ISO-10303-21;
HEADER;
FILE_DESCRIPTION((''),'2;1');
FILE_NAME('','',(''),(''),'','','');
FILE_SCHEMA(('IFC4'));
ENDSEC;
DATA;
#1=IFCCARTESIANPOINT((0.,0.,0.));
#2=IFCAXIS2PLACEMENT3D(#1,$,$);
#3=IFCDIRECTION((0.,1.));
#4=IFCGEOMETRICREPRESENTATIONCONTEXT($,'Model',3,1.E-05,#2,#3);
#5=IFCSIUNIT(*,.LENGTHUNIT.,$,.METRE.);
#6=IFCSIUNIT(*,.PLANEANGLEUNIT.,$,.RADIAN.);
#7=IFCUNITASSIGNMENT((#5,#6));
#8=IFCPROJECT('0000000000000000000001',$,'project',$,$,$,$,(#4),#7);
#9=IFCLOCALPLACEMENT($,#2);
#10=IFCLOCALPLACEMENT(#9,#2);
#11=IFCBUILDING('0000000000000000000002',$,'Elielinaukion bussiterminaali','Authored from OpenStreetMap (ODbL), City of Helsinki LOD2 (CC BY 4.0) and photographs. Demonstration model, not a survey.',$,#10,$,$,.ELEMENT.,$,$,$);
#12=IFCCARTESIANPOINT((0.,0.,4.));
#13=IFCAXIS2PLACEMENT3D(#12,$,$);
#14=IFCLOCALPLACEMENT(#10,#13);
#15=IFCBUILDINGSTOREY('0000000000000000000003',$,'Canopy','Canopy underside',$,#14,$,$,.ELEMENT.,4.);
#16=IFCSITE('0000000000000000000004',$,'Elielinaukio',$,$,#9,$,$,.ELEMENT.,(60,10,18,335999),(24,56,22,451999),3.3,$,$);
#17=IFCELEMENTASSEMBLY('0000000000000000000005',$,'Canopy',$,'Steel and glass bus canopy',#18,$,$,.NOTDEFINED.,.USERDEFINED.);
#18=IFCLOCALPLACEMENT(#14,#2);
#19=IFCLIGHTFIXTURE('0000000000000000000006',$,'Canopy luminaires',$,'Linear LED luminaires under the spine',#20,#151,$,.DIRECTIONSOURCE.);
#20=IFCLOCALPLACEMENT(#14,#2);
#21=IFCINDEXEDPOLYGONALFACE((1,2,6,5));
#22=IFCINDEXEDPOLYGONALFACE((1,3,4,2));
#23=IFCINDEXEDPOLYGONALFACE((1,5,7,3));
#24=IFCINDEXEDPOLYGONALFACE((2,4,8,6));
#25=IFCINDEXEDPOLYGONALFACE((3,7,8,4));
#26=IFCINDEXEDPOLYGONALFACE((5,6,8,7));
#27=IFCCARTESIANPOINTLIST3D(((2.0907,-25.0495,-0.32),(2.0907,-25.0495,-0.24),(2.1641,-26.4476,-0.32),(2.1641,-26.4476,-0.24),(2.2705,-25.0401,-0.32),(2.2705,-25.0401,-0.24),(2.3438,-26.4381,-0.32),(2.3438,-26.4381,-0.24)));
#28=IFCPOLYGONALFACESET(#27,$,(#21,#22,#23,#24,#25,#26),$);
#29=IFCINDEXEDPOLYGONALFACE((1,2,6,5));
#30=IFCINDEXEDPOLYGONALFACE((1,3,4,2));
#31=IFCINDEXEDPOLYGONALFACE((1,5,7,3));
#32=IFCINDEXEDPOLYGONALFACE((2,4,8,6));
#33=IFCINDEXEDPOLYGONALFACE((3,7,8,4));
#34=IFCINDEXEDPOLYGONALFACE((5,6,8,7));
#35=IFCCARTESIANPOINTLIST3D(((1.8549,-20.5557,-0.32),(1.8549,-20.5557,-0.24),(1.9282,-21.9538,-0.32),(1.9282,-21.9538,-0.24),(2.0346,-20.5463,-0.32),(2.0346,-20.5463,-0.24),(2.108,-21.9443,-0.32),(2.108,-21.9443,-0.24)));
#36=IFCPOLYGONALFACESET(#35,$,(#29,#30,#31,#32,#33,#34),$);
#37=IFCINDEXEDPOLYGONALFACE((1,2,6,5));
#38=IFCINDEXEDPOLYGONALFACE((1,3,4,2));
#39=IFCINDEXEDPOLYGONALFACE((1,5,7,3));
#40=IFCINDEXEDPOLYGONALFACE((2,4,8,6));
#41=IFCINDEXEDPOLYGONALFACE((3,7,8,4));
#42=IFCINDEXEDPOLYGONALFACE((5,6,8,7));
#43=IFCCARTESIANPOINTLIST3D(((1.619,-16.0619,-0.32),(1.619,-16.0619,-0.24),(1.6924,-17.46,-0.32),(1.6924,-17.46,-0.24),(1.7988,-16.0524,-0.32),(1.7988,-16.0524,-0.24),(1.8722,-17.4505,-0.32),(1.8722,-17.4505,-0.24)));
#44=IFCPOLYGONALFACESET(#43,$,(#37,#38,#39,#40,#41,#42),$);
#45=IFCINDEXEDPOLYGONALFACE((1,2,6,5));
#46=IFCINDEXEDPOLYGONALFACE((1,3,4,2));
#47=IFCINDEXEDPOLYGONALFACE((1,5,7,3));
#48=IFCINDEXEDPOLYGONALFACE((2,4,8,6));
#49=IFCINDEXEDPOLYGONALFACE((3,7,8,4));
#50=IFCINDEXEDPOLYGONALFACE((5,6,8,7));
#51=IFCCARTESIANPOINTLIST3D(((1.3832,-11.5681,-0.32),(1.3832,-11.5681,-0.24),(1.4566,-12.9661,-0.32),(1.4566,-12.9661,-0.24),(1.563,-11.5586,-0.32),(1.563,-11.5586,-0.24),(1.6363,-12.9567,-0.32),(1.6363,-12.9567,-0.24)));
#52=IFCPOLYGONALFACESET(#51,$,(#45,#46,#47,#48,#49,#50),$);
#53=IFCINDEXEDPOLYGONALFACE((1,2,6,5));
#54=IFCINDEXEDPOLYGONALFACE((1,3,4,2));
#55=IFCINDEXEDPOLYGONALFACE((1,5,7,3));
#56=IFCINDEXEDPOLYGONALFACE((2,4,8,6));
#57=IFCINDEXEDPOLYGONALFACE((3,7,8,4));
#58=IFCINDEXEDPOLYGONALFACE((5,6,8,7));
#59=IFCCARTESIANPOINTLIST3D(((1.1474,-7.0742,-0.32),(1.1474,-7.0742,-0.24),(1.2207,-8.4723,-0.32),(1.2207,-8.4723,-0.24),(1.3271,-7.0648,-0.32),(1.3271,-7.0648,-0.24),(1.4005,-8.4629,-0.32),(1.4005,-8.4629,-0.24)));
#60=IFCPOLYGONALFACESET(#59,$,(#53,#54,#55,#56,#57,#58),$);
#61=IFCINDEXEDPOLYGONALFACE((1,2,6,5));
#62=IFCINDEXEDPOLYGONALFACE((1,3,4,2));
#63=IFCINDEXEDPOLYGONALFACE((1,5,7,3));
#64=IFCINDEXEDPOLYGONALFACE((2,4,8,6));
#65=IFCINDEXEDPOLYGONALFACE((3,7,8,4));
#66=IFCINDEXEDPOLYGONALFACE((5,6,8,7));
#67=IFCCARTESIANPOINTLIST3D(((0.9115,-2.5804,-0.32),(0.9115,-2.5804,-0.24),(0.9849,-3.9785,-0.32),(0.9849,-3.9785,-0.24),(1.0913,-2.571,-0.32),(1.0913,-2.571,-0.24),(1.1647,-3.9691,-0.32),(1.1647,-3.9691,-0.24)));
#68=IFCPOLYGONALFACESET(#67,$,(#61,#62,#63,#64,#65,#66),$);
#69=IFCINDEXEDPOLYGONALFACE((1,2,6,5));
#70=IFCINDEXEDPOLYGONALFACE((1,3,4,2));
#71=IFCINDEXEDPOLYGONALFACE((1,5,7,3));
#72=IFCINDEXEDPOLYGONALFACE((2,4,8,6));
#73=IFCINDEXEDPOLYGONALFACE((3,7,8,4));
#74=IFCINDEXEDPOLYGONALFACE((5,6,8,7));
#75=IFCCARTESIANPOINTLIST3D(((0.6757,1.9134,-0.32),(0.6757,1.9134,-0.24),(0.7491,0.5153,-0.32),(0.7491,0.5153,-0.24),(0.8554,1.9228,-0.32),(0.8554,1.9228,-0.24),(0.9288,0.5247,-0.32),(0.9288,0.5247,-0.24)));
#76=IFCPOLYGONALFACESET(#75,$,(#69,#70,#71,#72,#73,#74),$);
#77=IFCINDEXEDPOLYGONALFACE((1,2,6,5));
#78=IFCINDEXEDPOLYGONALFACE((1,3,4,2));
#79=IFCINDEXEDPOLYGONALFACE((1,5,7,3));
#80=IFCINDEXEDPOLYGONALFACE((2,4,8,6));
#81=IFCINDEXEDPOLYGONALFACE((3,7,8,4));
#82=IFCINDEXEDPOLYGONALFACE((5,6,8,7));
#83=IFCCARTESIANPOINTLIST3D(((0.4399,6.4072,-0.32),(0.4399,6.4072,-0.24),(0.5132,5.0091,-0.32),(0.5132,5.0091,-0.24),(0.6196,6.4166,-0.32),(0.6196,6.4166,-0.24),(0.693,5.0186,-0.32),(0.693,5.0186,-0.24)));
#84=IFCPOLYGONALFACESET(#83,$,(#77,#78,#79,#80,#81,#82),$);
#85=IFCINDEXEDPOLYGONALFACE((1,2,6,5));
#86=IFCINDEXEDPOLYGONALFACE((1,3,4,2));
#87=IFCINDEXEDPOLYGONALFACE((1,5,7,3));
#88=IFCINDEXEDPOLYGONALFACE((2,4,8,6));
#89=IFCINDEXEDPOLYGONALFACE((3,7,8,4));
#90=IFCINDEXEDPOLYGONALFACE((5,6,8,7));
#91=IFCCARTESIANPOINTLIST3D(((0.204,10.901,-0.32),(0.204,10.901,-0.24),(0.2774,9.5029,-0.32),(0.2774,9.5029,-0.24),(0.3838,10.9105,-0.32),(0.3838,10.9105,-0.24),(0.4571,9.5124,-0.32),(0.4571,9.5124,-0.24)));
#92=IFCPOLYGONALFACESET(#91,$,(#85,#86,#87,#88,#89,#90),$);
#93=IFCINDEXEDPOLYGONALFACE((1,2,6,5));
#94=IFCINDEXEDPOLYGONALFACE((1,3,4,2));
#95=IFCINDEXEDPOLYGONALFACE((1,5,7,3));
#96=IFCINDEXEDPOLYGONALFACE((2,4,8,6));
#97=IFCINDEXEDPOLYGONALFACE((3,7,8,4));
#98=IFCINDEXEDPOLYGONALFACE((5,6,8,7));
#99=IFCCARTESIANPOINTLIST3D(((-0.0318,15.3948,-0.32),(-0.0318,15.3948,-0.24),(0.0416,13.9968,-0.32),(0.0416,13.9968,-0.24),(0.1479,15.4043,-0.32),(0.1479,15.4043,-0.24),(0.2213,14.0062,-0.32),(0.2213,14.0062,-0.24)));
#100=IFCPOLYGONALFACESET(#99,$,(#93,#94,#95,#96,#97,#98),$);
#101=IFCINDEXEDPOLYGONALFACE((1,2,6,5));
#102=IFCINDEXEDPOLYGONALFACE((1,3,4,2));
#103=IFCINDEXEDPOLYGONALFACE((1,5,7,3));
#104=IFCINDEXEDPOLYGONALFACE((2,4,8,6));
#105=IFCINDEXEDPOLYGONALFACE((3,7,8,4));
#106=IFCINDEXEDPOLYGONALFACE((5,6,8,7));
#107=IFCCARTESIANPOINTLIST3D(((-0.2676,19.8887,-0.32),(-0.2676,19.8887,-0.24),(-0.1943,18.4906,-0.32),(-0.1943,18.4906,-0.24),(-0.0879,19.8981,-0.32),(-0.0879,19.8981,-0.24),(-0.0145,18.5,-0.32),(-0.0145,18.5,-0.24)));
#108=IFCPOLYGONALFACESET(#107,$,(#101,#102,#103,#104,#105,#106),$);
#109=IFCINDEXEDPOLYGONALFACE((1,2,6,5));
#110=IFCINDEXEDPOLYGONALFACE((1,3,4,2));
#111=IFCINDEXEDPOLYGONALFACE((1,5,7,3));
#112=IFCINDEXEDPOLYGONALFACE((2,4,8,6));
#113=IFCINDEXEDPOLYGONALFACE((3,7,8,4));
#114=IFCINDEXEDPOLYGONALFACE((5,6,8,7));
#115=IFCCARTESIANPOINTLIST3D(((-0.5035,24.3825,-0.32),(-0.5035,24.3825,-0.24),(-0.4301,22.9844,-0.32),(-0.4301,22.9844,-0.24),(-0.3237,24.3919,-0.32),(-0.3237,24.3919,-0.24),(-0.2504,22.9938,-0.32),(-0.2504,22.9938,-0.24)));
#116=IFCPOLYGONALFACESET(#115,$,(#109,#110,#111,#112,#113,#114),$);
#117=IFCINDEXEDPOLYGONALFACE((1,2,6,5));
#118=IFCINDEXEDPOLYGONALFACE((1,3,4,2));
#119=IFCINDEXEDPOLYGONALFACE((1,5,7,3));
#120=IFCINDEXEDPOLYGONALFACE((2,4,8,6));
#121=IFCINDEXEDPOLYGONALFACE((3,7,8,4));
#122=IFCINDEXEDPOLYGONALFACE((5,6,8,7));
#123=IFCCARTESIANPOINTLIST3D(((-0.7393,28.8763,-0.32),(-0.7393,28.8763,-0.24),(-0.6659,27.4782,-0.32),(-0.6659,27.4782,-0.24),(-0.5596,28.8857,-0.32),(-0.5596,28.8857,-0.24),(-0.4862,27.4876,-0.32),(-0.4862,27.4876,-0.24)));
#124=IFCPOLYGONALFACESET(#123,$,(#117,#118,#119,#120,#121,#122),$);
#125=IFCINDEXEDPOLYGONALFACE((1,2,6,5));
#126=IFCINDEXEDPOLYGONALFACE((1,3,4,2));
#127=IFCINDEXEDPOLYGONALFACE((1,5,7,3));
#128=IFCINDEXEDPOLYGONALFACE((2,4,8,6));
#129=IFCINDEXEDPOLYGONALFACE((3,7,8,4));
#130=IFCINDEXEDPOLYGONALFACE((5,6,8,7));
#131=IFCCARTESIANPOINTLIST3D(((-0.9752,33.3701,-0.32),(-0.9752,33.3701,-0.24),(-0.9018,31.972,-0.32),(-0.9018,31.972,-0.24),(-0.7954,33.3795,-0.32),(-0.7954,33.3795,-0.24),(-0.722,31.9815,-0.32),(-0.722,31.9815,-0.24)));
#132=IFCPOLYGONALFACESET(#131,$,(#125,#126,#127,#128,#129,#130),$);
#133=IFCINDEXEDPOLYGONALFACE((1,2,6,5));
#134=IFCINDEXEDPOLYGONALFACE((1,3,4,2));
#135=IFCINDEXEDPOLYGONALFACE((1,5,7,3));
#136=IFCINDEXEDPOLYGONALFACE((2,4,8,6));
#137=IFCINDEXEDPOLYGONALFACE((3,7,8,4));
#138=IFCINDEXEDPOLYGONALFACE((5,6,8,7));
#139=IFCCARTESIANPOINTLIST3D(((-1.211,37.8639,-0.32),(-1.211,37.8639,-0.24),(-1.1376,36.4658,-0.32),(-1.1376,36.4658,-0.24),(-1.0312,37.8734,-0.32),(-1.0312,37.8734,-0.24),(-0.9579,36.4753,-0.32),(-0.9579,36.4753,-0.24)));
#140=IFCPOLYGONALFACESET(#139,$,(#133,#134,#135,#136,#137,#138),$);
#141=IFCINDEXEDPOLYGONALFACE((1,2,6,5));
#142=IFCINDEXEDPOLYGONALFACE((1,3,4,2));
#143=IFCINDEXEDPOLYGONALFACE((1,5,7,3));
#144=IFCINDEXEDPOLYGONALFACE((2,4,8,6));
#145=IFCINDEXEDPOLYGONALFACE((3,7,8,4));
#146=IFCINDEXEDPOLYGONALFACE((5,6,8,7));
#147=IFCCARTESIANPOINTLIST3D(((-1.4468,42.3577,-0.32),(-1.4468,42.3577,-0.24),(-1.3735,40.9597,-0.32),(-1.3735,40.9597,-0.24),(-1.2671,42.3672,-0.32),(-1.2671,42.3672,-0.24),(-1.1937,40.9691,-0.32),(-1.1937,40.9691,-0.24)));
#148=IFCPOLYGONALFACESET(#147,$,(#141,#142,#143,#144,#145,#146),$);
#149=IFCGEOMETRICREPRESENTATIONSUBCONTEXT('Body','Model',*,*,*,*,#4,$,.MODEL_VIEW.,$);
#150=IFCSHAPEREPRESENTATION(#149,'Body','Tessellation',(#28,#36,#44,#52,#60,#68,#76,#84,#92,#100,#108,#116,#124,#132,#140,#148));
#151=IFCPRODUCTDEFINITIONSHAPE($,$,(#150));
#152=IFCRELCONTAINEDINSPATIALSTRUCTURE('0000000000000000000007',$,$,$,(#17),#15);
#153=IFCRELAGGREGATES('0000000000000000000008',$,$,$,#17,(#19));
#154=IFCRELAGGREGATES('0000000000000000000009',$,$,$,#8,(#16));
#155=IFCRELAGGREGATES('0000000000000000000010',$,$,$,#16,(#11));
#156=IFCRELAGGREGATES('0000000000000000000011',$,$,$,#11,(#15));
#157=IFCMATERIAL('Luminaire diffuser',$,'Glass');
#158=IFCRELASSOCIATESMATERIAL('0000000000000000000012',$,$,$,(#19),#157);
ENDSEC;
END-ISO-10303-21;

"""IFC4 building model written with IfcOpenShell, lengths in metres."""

from ifc_helpers import new_model, si_unit, direction, frame, frame_2d, origin, place, context, subcontext, project, spatial, rectangle, extrude, material, element, aggregate, save


model = new_model("IFC4")

# Units and contexts
model_context = context("Model", 3, precision=1e-05, world=origin(), true_north=direction((0.0, 1.0)))
body_context = subcontext(model_context, "Body", "Model", "MODEL_VIEW")
ifc_project = project(units=[si_unit("LENGTHUNIT", "METRE"), si_unit("PLANEANGLEUNIT", "RADIAN")], contexts=[model_context])

# Site, building, storey
site_placement = place(None, origin())
site = spatial("IfcSite", under=ifc_project, at=site_placement, Name="Elielinaukio", CompositionType="ELEMENT", RefLatitude=(60, 10, 18, 335999), RefLongitude=(24, 56, 22, 451999), RefElevation=3.3)
building_placement = place(site_placement, origin())
building = spatial("IfcBuilding", under=site, at=building_placement, Name="Elielinaukion bussiterminaali", Description="Authored from OpenStreetMap (ODbL), City of Helsinki LOD2 (CC BY 4.0) and photographs. Demonstration model, not a survey.", CompositionType="ELEMENT")
storey_placement = place(building_placement, frame((0.0, 0.0, 4.0)))
storey = spatial("IfcBuildingStorey", under=building, at=storey_placement, Name="Canopy", Description="Canopy underside", CompositionType="ELEMENT", Elevation=4.0)

# Element assembly, light fixture
assembly_placement = place(building_placement, origin())
assembly = element("IfcElementAssembly", 1, at=assembly_placement, inside=storey, Name="Canopy", ObjectType="Steel and glass bus canopy", AssemblyPlace="NOTDEFINED", PredefinedType="USERDEFINED")
ifc_material_1 = material(Name="Luminaire diffuser", Category="Glass")
light_fixture_placement = place(building_placement, origin())
light_fixture = element("IfcLightFixture", 2, at=light_fixture_placement, material=ifc_material_1, Name="Canopy luminaires", ObjectType="Linear LED luminaires under the spine", PredefinedType="DIRECTIONSOURCE", context=body_context, shape_type="SweptSolid", body=[
    extrude(rectangle(XDim=1.4, YDim=0.18, at=frame_2d((0.0, 0.0), x_axis=(-0.052408, 0.998626))), frame((2.2173, -25.7438, 3.68)), (0.0, 0.0, 1.0), 0.08),
    extrude(rectangle(XDim=1.4, YDim=0.18, at=frame_2d((0.0, 0.0), x_axis=(-0.052408, 0.998626))), frame((1.9814, -21.25, 3.68)), (0.0, 0.0, 1.0), 0.08),
    extrude(rectangle(XDim=1.4, YDim=0.18, at=frame_2d((0.0, 0.0), x_axis=(-0.052408, 0.998626))), frame((1.7456, -16.7562, 3.68)), (0.0, 0.0, 1.0), 0.08),
    extrude(rectangle(XDim=1.4, YDim=0.18, at=frame_2d((0.0, 0.0), x_axis=(-0.052408, 0.998626))), frame((1.5098, -12.2624, 3.68)), (0.0, 0.0, 1.0), 0.08),
    extrude(rectangle(XDim=1.4, YDim=0.18, at=frame_2d((0.0, 0.0), x_axis=(-0.052408, 0.998626))), frame((1.2739, -7.7686, 3.68)), (0.0, 0.0, 1.0), 0.08),
    extrude(rectangle(XDim=1.4, YDim=0.18, at=frame_2d((0.0, 0.0), x_axis=(-0.052408, 0.998626))), frame((1.0381, -3.2747, 3.68)), (0.0, 0.0, 1.0), 0.08),
    extrude(rectangle(XDim=1.4, YDim=0.18, at=frame_2d((0.0, 0.0), x_axis=(-0.052408, 0.998626))), frame((0.8023, 1.2191, 3.68)), (0.0, 0.0, 1.0), 0.08),
    extrude(rectangle(XDim=1.4, YDim=0.18, at=frame_2d((0.0, 0.0), x_axis=(-0.052408, 0.998626))), frame((0.5664, 5.7129, 3.68)), (0.0, 0.0, 1.0), 0.08),
    extrude(rectangle(XDim=1.4, YDim=0.18, at=frame_2d((0.0, 0.0), x_axis=(-0.052408, 0.998626))), frame((0.3306, 10.2067, 3.68)), (0.0, 0.0, 1.0), 0.08),
    extrude(rectangle(XDim=1.4, YDim=0.18, at=frame_2d((0.0, 0.0), x_axis=(-0.052408, 0.998626))), frame((0.0948, 14.7005, 3.68)), (0.0, 0.0, 1.0), 0.08),
    extrude(rectangle(XDim=1.4, YDim=0.18, at=frame_2d((0.0, 0.0), x_axis=(-0.052408, 0.998626))), frame((-0.1411, 19.1943, 3.68)), (0.0, 0.0, 1.0), 0.08),
    extrude(rectangle(XDim=1.4, YDim=0.18, at=frame_2d((0.0, 0.0), x_axis=(-0.052408, 0.998626))), frame((-0.3769, 23.6881, 3.68)), (0.0, 0.0, 1.0), 0.08),
    extrude(rectangle(XDim=1.4, YDim=0.18, at=frame_2d((0.0, 0.0), x_axis=(-0.052408, 0.998626))), frame((-0.6128, 28.182, 3.68)), (0.0, 0.0, 1.0), 0.08),
    extrude(rectangle(XDim=1.4, YDim=0.18, at=frame_2d((0.0, 0.0), x_axis=(-0.052408, 0.998626))), frame((-0.8486, 32.6758, 3.68)), (0.0, 0.0, 1.0), 0.08),
    extrude(rectangle(XDim=1.4, YDim=0.18, at=frame_2d((0.0, 0.0), x_axis=(-0.052408, 0.998626))), frame((-1.0844, 37.1696, 3.68)), (0.0, 0.0, 1.0), 0.08),
    extrude(rectangle(XDim=1.4, YDim=0.18, at=frame_2d((0.0, 0.0), x_axis=(-0.052408, 0.998626))), frame((-1.3203, 41.6634, 3.68)), (0.0, 0.0, 1.0), 0.08),
])
aggregate(assembly, [light_fixture])

save(model, "model.ifc")
